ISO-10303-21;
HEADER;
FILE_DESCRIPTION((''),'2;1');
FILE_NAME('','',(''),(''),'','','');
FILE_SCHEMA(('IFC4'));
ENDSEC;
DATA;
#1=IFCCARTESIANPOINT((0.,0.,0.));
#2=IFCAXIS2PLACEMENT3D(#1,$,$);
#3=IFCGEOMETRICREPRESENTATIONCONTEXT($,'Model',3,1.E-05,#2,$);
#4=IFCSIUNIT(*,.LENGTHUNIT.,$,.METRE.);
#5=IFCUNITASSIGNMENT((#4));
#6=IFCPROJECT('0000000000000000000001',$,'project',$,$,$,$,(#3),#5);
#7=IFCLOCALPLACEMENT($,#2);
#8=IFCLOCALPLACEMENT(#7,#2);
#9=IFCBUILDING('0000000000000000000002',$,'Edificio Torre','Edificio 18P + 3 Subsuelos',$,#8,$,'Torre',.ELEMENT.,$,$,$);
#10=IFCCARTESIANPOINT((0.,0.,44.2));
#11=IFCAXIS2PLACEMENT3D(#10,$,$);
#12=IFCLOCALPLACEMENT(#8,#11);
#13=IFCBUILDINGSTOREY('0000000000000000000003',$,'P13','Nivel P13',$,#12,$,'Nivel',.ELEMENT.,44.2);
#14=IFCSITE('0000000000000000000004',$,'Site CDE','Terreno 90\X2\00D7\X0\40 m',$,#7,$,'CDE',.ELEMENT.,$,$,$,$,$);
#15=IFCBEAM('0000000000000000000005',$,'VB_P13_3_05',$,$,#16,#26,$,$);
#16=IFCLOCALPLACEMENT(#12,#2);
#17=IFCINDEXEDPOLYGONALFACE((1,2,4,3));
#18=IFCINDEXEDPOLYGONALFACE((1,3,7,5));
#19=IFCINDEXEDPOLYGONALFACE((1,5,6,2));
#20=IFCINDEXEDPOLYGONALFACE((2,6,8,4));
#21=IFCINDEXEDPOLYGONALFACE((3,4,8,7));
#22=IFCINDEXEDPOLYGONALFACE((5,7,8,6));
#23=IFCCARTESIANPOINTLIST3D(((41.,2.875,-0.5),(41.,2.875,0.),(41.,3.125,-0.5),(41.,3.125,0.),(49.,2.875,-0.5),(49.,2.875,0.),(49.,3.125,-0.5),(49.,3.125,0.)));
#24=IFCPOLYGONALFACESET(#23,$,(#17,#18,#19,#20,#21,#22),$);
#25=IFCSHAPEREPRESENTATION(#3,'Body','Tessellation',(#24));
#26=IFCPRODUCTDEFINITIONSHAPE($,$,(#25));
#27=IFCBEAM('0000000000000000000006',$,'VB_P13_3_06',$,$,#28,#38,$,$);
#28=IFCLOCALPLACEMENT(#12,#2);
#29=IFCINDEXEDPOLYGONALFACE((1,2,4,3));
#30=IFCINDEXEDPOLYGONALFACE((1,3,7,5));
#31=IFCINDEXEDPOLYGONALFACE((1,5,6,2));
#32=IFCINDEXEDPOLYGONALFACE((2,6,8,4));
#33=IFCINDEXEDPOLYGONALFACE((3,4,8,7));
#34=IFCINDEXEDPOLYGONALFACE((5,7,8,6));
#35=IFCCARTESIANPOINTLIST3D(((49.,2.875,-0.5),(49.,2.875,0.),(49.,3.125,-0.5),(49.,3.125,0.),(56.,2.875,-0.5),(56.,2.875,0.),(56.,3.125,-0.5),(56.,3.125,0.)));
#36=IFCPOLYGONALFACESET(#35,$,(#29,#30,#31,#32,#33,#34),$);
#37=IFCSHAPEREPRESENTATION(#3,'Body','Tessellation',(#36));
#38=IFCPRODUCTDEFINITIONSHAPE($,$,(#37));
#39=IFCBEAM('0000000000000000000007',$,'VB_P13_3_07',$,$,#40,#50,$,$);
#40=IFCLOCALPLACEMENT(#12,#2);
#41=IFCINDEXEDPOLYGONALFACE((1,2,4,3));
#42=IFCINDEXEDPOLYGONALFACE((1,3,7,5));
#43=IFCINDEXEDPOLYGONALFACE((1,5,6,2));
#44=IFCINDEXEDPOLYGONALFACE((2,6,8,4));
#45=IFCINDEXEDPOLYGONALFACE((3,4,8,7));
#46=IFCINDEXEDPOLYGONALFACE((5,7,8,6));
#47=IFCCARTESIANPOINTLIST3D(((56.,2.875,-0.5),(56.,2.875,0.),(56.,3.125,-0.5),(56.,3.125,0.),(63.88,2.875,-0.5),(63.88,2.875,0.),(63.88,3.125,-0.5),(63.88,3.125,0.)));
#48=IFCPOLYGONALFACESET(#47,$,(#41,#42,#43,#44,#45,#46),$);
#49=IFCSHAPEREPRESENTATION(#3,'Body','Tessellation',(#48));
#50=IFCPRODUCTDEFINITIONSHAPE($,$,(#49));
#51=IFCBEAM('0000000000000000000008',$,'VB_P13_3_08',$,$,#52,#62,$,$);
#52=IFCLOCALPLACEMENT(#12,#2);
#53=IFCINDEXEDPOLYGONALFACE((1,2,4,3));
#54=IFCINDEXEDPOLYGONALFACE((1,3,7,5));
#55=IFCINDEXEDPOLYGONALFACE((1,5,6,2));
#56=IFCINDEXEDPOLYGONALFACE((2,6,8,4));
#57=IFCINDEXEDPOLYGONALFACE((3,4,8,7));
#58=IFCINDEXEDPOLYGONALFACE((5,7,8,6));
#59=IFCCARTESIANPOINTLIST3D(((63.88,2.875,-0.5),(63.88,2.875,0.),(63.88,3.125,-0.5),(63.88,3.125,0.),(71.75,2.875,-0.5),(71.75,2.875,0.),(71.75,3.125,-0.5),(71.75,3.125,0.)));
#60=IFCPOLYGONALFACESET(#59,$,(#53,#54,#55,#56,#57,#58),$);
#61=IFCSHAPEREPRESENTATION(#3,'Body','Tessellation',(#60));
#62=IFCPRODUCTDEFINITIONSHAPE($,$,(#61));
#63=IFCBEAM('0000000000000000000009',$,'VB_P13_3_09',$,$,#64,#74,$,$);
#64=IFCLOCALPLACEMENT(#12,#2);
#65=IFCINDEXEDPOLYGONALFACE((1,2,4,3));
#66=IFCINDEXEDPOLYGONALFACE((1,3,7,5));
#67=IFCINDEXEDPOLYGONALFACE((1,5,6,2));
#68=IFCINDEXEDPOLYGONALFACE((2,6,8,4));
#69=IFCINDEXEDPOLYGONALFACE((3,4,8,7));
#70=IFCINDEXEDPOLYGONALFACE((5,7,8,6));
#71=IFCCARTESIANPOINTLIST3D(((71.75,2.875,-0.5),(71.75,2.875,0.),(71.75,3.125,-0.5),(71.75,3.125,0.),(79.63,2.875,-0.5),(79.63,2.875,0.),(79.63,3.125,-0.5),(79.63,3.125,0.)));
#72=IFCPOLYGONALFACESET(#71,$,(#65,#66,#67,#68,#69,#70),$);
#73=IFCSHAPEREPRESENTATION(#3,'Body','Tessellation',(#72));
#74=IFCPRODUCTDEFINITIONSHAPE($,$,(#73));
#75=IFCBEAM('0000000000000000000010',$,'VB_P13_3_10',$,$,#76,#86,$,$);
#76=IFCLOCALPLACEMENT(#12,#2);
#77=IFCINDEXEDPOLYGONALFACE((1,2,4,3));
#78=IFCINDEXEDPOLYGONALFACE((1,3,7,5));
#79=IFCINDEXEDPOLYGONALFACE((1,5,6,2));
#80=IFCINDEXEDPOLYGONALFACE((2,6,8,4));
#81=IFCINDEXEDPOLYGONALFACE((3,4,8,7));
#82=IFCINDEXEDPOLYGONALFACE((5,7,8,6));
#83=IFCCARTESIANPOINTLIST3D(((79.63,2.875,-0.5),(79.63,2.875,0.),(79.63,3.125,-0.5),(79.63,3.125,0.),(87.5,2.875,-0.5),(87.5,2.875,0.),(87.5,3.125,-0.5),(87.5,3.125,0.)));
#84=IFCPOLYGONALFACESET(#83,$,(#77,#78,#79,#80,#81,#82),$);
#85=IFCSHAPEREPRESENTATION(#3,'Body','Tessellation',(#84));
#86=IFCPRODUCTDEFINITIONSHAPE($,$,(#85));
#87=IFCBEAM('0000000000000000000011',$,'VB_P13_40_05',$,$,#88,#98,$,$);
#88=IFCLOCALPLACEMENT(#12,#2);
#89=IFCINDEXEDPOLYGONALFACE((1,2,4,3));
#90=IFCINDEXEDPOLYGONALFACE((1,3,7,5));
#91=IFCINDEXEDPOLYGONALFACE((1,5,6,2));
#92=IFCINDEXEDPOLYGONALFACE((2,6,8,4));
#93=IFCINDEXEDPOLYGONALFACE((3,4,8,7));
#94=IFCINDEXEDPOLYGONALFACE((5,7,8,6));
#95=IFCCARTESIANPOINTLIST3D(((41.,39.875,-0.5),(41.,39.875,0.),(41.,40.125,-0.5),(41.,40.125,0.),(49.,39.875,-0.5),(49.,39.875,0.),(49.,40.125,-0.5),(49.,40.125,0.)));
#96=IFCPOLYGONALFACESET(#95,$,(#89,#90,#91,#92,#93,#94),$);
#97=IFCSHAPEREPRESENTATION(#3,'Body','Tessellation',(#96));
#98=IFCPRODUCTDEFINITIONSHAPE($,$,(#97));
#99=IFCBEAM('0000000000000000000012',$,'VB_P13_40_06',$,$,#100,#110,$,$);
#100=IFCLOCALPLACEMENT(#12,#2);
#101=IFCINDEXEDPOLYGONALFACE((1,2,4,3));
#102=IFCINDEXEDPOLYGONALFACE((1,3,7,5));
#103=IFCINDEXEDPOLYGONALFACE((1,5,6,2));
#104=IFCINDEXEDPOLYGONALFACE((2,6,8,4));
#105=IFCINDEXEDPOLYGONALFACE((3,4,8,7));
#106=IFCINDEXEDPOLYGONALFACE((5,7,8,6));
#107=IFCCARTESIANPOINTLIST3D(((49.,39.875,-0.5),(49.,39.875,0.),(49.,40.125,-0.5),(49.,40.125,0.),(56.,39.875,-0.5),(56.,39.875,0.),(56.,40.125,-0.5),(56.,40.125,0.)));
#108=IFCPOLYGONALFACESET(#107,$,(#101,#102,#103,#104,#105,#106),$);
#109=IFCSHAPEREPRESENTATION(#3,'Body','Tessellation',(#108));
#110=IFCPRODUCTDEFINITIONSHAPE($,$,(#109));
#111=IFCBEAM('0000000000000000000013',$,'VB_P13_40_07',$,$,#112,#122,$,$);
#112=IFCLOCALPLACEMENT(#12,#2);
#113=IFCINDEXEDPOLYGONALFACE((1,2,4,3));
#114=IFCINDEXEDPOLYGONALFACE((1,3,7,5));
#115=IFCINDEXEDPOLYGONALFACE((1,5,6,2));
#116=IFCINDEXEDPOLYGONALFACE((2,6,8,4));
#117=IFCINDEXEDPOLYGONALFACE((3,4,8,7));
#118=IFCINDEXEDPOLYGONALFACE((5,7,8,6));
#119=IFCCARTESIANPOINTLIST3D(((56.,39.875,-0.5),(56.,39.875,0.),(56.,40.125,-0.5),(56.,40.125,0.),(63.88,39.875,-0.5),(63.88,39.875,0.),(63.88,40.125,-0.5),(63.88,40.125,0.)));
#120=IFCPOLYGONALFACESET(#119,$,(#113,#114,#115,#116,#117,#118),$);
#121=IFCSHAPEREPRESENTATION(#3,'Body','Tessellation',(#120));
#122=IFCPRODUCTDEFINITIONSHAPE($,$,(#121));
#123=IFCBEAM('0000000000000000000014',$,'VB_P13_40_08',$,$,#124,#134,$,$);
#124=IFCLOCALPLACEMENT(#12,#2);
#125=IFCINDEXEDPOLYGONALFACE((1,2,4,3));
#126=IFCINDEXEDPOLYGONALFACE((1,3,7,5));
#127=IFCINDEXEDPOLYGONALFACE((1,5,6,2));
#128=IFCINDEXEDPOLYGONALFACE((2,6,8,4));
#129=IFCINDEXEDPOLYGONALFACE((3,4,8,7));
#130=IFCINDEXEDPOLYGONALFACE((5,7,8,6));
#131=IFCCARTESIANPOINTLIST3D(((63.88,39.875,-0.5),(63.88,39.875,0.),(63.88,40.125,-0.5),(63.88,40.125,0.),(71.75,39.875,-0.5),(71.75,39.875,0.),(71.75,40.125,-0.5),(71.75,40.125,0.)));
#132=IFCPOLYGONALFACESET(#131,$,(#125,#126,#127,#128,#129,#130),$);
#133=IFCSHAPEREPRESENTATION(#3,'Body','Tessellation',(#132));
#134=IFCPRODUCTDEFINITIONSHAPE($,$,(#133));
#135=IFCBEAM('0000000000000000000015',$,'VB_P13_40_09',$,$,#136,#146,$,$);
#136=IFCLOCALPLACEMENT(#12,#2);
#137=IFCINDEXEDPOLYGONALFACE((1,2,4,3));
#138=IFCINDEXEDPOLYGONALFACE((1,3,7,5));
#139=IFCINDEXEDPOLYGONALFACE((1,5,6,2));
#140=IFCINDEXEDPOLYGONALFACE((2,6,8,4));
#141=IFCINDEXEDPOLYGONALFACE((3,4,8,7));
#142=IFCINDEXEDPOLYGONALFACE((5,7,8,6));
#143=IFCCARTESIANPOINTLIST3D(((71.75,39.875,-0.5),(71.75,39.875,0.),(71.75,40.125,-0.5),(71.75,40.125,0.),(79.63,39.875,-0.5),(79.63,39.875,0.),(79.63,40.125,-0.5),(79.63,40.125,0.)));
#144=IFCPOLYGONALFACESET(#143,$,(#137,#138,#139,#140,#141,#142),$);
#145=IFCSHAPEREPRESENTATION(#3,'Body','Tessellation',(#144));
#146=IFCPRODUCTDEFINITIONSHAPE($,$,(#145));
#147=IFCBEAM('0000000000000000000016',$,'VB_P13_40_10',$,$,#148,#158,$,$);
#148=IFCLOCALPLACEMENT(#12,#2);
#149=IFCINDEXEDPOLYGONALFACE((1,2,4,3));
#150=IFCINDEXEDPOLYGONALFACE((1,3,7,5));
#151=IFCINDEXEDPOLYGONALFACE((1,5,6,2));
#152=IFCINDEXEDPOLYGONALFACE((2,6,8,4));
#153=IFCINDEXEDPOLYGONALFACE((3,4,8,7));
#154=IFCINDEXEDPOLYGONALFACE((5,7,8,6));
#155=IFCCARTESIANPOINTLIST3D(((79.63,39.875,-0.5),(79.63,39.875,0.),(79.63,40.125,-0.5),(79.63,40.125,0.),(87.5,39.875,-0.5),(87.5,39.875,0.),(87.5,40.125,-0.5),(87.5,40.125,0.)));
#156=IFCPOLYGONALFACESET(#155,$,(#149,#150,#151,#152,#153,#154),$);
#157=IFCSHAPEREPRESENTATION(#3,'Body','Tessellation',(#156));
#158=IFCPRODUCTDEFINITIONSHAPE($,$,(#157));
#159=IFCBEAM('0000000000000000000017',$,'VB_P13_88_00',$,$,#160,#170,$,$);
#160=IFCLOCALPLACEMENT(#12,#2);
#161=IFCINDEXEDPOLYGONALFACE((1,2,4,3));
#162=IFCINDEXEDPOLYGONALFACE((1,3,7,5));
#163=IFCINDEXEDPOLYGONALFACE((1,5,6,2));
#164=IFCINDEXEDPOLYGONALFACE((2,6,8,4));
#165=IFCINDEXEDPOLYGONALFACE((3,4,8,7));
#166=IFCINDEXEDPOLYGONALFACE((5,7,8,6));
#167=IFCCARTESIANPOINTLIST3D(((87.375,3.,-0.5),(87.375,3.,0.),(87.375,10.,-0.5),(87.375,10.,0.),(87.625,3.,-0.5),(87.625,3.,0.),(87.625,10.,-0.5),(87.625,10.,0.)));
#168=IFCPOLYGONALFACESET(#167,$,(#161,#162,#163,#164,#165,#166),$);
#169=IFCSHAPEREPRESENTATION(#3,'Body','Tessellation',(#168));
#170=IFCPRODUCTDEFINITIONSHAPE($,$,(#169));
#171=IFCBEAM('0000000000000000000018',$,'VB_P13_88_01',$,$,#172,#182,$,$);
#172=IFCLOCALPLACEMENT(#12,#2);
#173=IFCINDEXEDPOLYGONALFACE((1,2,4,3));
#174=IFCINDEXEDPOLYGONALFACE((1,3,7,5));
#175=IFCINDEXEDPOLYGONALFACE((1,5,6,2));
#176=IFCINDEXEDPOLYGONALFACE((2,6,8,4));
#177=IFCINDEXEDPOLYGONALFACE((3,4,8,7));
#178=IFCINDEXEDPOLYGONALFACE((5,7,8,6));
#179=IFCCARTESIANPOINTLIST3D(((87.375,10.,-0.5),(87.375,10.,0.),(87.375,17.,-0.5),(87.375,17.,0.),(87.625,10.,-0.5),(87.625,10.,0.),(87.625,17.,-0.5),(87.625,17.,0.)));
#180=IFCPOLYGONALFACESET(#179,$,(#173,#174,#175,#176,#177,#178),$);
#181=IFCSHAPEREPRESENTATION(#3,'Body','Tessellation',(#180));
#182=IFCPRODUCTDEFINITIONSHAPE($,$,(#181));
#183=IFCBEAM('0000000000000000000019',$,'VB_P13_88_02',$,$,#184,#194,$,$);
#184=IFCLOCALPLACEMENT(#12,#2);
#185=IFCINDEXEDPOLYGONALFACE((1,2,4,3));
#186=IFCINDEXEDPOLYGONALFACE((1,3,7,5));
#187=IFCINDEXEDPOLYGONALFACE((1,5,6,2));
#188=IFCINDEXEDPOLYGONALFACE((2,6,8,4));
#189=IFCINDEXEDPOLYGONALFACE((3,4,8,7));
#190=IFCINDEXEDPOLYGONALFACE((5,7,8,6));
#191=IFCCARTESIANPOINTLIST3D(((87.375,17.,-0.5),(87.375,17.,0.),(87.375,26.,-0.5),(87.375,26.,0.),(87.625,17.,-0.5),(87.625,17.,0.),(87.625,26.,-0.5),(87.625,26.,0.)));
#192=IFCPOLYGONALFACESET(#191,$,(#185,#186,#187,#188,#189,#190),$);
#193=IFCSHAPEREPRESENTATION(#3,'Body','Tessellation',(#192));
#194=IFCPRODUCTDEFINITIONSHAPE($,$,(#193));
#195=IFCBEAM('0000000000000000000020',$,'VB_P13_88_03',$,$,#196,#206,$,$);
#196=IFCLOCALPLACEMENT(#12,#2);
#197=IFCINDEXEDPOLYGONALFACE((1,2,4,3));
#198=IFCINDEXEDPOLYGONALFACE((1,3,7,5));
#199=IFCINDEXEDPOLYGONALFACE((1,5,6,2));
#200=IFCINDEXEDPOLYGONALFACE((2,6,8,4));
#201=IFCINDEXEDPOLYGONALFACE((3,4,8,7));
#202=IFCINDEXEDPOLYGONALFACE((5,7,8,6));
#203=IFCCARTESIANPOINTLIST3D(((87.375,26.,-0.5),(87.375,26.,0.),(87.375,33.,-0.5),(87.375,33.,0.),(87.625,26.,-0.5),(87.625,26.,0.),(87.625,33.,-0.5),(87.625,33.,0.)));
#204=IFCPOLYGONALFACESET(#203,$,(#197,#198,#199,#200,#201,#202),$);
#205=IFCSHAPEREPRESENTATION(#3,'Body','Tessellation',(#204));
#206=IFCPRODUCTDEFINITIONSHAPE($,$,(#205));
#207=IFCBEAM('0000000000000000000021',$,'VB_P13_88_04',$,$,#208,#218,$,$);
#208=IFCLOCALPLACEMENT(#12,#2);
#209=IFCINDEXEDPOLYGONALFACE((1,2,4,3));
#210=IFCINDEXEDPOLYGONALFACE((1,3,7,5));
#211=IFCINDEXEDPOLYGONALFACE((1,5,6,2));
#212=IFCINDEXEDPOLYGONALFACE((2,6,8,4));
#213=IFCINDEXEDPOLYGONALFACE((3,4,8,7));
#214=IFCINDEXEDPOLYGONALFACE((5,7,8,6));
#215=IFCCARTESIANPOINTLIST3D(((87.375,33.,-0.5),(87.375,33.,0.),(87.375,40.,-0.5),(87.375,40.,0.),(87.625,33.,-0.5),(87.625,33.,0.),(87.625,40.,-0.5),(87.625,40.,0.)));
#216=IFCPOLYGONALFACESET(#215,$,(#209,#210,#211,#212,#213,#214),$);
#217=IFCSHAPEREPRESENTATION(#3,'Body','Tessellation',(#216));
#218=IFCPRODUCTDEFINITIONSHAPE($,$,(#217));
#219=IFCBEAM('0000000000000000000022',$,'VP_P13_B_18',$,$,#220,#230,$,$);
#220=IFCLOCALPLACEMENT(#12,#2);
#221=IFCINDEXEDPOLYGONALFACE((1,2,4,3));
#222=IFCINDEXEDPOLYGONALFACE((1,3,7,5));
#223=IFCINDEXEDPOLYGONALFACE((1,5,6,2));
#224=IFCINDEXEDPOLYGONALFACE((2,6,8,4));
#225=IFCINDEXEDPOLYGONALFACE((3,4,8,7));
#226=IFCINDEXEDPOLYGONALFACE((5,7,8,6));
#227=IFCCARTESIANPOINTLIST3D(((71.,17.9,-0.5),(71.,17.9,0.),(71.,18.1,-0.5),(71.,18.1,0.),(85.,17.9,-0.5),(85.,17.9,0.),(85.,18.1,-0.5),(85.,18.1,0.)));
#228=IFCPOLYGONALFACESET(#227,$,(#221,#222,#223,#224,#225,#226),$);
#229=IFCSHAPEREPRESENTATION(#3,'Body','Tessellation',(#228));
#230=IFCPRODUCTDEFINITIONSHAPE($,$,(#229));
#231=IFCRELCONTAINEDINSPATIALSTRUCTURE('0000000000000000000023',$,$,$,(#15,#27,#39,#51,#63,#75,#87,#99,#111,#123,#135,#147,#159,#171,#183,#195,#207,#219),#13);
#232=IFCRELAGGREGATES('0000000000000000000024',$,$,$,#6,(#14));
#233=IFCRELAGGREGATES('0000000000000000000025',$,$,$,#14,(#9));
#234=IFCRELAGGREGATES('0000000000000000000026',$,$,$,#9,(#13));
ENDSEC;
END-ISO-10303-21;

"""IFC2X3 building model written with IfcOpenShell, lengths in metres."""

from ifc_helpers import new_model, si_unit, frame, origin, origin_2d, place, context, project, spatial, rectangle, extrude, element, save


model = new_model("IFC2X3")

# Units and contexts
model_context = context("Model", 3, precision=1e-05, world=origin())
ifc_project = project(units=[si_unit("LENGTHUNIT", "METRE")], contexts=[model_context])

# Site, building, storey
site_placement = place(None, origin())
site = spatial("IfcSite", under=ifc_project, at=site_placement, Name="Site CDE", Description="Terreno 90×40 m", LongName="CDE", CompositionType="ELEMENT")
building_placement = place(site_placement, origin())
building = spatial("IfcBuilding", under=site, at=building_placement, Name="Edificio Torre", Description="Edificio 18P + 3 Subsuelos", LongName="Torre", CompositionType="ELEMENT")
storey_placement = place(building_placement, frame((0.0, 0.0, 44.2)))
storey = spatial("IfcBuildingStorey", under=building, at=storey_placement, Name="P13", Description="Nivel P13", LongName="Nivel", CompositionType="ELEMENT", Elevation=44.2)

# Beams
beam_1_placement = place(storey_placement, frame((45.0, 3.0, -0.5)))
element("IfcBeam", 1, at=beam_1_placement, inside=storey, Name="VB_P13_3_05", context=model_context, shape_type="SweptSolid", body=[
    extrude(rectangle(XDim=8.0, YDim=0.25, at=origin_2d()), origin(), (0.0, 0.0, 1.0), 0.5),
])
beam_2_placement = place(storey_placement, frame((52.5, 3.0, -0.5)))
element("IfcBeam", 2, at=beam_2_placement, inside=storey, Name="VB_P13_3_06", context=model_context, shape_type="SweptSolid", body=[
    extrude(rectangle(XDim=7.0, YDim=0.25, at=origin_2d()), origin(), (0.0, 0.0, 1.0), 0.5),
])
beam_3_placement = place(storey_placement, frame((59.94, 3.0, -0.5)))
element("IfcBeam", 3, at=beam_3_placement, inside=storey, Name="VB_P13_3_07", context=model_context, shape_type="SweptSolid", body=[
    extrude(rectangle(XDim=7.88, YDim=0.25, at=origin_2d()), origin(), (0.0, 0.0, 1.0), 0.5),
])
beam_4_placement = place(storey_placement, frame((67.815, 3.0, -0.5)))
element("IfcBeam", 4, at=beam_4_placement, inside=storey, Name="VB_P13_3_08", context=model_context, shape_type="SweptSolid", body=[
    extrude(rectangle(XDim=7.87, YDim=0.25, at=origin_2d()), origin(), (0.0, 0.0, 1.0), 0.5),
])
beam_5_placement = place(storey_placement, frame((75.69, 3.0, -0.5)))
element("IfcBeam", 5, at=beam_5_placement, inside=storey, Name="VB_P13_3_09", context=model_context, shape_type="SweptSolid", body=[
    extrude(rectangle(XDim=7.88, YDim=0.25, at=origin_2d()), origin(), (0.0, 0.0, 1.0), 0.5),
])
beam_6_placement = place(storey_placement, frame((83.565, 3.0, -0.5)))
element("IfcBeam", 6, at=beam_6_placement, inside=storey, Name="VB_P13_3_10", context=model_context, shape_type="SweptSolid", body=[
    extrude(rectangle(XDim=7.87, YDim=0.25, at=origin_2d()), origin(), (0.0, 0.0, 1.0), 0.5),
])
beam_7_placement = place(storey_placement, frame((45.0, 40.0, -0.5)))
element("IfcBeam", 7, at=beam_7_placement, inside=storey, Name="VB_P13_40_05", context=model_context, shape_type="SweptSolid", body=[
    extrude(rectangle(XDim=8.0, YDim=0.25, at=origin_2d()), origin(), (0.0, 0.0, 1.0), 0.5),
])
beam_8_placement = place(storey_placement, frame((52.5, 40.0, -0.5)))
element("IfcBeam", 8, at=beam_8_placement, inside=storey, Name="VB_P13_40_06", context=model_context, shape_type="SweptSolid", body=[
    extrude(rectangle(XDim=7.0, YDim=0.25, at=origin_2d()), origin(), (0.0, 0.0, 1.0), 0.5),
])
beam_9_placement = place(storey_placement, frame((59.94, 40.0, -0.5)))
element("IfcBeam", 9, at=beam_9_placement, inside=storey, Name="VB_P13_40_07", context=model_context, shape_type="SweptSolid", body=[
    extrude(rectangle(XDim=7.88, YDim=0.25, at=origin_2d()), origin(), (0.0, 0.0, 1.0), 0.5),
])
beam_10_placement = place(storey_placement, frame((67.815, 40.0, -0.5)))
element("IfcBeam", 10, at=beam_10_placement, inside=storey, Name="VB_P13_40_08", context=model_context, shape_type="SweptSolid", body=[
    extrude(rectangle(XDim=7.87, YDim=0.25, at=origin_2d()), origin(), (0.0, 0.0, 1.0), 0.5),
])
beam_11_placement = place(storey_placement, frame((75.69, 40.0, -0.5)))
element("IfcBeam", 11, at=beam_11_placement, inside=storey, Name="VB_P13_40_09", context=model_context, shape_type="SweptSolid", body=[
    extrude(rectangle(XDim=7.88, YDim=0.25, at=origin_2d()), origin(), (0.0, 0.0, 1.0), 0.5),
])
beam_12_placement = place(storey_placement, frame((83.565, 40.0, -0.5)))
element("IfcBeam", 12, at=beam_12_placement, inside=storey, Name="VB_P13_40_10", context=model_context, shape_type="SweptSolid", body=[
    extrude(rectangle(XDim=7.87, YDim=0.25, at=origin_2d()), origin(), (0.0, 0.0, 1.0), 0.5),
])
for number, where, name in (
    (13, (87.5, 6.5, -0.5), "VB_P13_88_00"),
    (14, (87.5, 13.5, -0.5), "VB_P13_88_01"),
):
    element("IfcBeam", number, at=place(storey_placement, frame(where)), inside=storey, Name=name, context=model_context, shape_type="SweptSolid", body=[
        extrude(rectangle(XDim=0.25, YDim=7.0, at=origin_2d()), origin(), (0.0, 0.0, 1.0), 0.5),
    ])
beam_13_placement = place(storey_placement, frame((87.5, 21.5, -0.5)))
element("IfcBeam", 15, at=beam_13_placement, inside=storey, Name="VB_P13_88_02", context=model_context, shape_type="SweptSolid", body=[
    extrude(rectangle(XDim=0.25, YDim=9.0, at=origin_2d()), origin(), (0.0, 0.0, 1.0), 0.5),
])
for number, where, name in (
    (16, (87.5, 29.5, -0.5), "VB_P13_88_03"),
    (17, (87.5, 36.5, -0.5), "VB_P13_88_04"),
):
    element("IfcBeam", number, at=place(storey_placement, frame(where)), inside=storey, Name=name, context=model_context, shape_type="SweptSolid", body=[
        extrude(rectangle(XDim=0.25, YDim=7.0, at=origin_2d()), origin(), (0.0, 0.0, 1.0), 0.5),
    ])
for number, where, name in (
    (18, (78.0, 18.0, -0.5), "VP_P13_B_18"),
):
    element("IfcBeam", number, at=place(storey_placement, frame(where)), inside=storey, Name=name, context=model_context, shape_type="SweptSolid", body=[
        extrude(rectangle(XDim=14.0, YDim=0.2, at=origin_2d()), origin(), (0.0, 0.0, 1.0), 0.5),
    ])

save(model, "model.ifc")
